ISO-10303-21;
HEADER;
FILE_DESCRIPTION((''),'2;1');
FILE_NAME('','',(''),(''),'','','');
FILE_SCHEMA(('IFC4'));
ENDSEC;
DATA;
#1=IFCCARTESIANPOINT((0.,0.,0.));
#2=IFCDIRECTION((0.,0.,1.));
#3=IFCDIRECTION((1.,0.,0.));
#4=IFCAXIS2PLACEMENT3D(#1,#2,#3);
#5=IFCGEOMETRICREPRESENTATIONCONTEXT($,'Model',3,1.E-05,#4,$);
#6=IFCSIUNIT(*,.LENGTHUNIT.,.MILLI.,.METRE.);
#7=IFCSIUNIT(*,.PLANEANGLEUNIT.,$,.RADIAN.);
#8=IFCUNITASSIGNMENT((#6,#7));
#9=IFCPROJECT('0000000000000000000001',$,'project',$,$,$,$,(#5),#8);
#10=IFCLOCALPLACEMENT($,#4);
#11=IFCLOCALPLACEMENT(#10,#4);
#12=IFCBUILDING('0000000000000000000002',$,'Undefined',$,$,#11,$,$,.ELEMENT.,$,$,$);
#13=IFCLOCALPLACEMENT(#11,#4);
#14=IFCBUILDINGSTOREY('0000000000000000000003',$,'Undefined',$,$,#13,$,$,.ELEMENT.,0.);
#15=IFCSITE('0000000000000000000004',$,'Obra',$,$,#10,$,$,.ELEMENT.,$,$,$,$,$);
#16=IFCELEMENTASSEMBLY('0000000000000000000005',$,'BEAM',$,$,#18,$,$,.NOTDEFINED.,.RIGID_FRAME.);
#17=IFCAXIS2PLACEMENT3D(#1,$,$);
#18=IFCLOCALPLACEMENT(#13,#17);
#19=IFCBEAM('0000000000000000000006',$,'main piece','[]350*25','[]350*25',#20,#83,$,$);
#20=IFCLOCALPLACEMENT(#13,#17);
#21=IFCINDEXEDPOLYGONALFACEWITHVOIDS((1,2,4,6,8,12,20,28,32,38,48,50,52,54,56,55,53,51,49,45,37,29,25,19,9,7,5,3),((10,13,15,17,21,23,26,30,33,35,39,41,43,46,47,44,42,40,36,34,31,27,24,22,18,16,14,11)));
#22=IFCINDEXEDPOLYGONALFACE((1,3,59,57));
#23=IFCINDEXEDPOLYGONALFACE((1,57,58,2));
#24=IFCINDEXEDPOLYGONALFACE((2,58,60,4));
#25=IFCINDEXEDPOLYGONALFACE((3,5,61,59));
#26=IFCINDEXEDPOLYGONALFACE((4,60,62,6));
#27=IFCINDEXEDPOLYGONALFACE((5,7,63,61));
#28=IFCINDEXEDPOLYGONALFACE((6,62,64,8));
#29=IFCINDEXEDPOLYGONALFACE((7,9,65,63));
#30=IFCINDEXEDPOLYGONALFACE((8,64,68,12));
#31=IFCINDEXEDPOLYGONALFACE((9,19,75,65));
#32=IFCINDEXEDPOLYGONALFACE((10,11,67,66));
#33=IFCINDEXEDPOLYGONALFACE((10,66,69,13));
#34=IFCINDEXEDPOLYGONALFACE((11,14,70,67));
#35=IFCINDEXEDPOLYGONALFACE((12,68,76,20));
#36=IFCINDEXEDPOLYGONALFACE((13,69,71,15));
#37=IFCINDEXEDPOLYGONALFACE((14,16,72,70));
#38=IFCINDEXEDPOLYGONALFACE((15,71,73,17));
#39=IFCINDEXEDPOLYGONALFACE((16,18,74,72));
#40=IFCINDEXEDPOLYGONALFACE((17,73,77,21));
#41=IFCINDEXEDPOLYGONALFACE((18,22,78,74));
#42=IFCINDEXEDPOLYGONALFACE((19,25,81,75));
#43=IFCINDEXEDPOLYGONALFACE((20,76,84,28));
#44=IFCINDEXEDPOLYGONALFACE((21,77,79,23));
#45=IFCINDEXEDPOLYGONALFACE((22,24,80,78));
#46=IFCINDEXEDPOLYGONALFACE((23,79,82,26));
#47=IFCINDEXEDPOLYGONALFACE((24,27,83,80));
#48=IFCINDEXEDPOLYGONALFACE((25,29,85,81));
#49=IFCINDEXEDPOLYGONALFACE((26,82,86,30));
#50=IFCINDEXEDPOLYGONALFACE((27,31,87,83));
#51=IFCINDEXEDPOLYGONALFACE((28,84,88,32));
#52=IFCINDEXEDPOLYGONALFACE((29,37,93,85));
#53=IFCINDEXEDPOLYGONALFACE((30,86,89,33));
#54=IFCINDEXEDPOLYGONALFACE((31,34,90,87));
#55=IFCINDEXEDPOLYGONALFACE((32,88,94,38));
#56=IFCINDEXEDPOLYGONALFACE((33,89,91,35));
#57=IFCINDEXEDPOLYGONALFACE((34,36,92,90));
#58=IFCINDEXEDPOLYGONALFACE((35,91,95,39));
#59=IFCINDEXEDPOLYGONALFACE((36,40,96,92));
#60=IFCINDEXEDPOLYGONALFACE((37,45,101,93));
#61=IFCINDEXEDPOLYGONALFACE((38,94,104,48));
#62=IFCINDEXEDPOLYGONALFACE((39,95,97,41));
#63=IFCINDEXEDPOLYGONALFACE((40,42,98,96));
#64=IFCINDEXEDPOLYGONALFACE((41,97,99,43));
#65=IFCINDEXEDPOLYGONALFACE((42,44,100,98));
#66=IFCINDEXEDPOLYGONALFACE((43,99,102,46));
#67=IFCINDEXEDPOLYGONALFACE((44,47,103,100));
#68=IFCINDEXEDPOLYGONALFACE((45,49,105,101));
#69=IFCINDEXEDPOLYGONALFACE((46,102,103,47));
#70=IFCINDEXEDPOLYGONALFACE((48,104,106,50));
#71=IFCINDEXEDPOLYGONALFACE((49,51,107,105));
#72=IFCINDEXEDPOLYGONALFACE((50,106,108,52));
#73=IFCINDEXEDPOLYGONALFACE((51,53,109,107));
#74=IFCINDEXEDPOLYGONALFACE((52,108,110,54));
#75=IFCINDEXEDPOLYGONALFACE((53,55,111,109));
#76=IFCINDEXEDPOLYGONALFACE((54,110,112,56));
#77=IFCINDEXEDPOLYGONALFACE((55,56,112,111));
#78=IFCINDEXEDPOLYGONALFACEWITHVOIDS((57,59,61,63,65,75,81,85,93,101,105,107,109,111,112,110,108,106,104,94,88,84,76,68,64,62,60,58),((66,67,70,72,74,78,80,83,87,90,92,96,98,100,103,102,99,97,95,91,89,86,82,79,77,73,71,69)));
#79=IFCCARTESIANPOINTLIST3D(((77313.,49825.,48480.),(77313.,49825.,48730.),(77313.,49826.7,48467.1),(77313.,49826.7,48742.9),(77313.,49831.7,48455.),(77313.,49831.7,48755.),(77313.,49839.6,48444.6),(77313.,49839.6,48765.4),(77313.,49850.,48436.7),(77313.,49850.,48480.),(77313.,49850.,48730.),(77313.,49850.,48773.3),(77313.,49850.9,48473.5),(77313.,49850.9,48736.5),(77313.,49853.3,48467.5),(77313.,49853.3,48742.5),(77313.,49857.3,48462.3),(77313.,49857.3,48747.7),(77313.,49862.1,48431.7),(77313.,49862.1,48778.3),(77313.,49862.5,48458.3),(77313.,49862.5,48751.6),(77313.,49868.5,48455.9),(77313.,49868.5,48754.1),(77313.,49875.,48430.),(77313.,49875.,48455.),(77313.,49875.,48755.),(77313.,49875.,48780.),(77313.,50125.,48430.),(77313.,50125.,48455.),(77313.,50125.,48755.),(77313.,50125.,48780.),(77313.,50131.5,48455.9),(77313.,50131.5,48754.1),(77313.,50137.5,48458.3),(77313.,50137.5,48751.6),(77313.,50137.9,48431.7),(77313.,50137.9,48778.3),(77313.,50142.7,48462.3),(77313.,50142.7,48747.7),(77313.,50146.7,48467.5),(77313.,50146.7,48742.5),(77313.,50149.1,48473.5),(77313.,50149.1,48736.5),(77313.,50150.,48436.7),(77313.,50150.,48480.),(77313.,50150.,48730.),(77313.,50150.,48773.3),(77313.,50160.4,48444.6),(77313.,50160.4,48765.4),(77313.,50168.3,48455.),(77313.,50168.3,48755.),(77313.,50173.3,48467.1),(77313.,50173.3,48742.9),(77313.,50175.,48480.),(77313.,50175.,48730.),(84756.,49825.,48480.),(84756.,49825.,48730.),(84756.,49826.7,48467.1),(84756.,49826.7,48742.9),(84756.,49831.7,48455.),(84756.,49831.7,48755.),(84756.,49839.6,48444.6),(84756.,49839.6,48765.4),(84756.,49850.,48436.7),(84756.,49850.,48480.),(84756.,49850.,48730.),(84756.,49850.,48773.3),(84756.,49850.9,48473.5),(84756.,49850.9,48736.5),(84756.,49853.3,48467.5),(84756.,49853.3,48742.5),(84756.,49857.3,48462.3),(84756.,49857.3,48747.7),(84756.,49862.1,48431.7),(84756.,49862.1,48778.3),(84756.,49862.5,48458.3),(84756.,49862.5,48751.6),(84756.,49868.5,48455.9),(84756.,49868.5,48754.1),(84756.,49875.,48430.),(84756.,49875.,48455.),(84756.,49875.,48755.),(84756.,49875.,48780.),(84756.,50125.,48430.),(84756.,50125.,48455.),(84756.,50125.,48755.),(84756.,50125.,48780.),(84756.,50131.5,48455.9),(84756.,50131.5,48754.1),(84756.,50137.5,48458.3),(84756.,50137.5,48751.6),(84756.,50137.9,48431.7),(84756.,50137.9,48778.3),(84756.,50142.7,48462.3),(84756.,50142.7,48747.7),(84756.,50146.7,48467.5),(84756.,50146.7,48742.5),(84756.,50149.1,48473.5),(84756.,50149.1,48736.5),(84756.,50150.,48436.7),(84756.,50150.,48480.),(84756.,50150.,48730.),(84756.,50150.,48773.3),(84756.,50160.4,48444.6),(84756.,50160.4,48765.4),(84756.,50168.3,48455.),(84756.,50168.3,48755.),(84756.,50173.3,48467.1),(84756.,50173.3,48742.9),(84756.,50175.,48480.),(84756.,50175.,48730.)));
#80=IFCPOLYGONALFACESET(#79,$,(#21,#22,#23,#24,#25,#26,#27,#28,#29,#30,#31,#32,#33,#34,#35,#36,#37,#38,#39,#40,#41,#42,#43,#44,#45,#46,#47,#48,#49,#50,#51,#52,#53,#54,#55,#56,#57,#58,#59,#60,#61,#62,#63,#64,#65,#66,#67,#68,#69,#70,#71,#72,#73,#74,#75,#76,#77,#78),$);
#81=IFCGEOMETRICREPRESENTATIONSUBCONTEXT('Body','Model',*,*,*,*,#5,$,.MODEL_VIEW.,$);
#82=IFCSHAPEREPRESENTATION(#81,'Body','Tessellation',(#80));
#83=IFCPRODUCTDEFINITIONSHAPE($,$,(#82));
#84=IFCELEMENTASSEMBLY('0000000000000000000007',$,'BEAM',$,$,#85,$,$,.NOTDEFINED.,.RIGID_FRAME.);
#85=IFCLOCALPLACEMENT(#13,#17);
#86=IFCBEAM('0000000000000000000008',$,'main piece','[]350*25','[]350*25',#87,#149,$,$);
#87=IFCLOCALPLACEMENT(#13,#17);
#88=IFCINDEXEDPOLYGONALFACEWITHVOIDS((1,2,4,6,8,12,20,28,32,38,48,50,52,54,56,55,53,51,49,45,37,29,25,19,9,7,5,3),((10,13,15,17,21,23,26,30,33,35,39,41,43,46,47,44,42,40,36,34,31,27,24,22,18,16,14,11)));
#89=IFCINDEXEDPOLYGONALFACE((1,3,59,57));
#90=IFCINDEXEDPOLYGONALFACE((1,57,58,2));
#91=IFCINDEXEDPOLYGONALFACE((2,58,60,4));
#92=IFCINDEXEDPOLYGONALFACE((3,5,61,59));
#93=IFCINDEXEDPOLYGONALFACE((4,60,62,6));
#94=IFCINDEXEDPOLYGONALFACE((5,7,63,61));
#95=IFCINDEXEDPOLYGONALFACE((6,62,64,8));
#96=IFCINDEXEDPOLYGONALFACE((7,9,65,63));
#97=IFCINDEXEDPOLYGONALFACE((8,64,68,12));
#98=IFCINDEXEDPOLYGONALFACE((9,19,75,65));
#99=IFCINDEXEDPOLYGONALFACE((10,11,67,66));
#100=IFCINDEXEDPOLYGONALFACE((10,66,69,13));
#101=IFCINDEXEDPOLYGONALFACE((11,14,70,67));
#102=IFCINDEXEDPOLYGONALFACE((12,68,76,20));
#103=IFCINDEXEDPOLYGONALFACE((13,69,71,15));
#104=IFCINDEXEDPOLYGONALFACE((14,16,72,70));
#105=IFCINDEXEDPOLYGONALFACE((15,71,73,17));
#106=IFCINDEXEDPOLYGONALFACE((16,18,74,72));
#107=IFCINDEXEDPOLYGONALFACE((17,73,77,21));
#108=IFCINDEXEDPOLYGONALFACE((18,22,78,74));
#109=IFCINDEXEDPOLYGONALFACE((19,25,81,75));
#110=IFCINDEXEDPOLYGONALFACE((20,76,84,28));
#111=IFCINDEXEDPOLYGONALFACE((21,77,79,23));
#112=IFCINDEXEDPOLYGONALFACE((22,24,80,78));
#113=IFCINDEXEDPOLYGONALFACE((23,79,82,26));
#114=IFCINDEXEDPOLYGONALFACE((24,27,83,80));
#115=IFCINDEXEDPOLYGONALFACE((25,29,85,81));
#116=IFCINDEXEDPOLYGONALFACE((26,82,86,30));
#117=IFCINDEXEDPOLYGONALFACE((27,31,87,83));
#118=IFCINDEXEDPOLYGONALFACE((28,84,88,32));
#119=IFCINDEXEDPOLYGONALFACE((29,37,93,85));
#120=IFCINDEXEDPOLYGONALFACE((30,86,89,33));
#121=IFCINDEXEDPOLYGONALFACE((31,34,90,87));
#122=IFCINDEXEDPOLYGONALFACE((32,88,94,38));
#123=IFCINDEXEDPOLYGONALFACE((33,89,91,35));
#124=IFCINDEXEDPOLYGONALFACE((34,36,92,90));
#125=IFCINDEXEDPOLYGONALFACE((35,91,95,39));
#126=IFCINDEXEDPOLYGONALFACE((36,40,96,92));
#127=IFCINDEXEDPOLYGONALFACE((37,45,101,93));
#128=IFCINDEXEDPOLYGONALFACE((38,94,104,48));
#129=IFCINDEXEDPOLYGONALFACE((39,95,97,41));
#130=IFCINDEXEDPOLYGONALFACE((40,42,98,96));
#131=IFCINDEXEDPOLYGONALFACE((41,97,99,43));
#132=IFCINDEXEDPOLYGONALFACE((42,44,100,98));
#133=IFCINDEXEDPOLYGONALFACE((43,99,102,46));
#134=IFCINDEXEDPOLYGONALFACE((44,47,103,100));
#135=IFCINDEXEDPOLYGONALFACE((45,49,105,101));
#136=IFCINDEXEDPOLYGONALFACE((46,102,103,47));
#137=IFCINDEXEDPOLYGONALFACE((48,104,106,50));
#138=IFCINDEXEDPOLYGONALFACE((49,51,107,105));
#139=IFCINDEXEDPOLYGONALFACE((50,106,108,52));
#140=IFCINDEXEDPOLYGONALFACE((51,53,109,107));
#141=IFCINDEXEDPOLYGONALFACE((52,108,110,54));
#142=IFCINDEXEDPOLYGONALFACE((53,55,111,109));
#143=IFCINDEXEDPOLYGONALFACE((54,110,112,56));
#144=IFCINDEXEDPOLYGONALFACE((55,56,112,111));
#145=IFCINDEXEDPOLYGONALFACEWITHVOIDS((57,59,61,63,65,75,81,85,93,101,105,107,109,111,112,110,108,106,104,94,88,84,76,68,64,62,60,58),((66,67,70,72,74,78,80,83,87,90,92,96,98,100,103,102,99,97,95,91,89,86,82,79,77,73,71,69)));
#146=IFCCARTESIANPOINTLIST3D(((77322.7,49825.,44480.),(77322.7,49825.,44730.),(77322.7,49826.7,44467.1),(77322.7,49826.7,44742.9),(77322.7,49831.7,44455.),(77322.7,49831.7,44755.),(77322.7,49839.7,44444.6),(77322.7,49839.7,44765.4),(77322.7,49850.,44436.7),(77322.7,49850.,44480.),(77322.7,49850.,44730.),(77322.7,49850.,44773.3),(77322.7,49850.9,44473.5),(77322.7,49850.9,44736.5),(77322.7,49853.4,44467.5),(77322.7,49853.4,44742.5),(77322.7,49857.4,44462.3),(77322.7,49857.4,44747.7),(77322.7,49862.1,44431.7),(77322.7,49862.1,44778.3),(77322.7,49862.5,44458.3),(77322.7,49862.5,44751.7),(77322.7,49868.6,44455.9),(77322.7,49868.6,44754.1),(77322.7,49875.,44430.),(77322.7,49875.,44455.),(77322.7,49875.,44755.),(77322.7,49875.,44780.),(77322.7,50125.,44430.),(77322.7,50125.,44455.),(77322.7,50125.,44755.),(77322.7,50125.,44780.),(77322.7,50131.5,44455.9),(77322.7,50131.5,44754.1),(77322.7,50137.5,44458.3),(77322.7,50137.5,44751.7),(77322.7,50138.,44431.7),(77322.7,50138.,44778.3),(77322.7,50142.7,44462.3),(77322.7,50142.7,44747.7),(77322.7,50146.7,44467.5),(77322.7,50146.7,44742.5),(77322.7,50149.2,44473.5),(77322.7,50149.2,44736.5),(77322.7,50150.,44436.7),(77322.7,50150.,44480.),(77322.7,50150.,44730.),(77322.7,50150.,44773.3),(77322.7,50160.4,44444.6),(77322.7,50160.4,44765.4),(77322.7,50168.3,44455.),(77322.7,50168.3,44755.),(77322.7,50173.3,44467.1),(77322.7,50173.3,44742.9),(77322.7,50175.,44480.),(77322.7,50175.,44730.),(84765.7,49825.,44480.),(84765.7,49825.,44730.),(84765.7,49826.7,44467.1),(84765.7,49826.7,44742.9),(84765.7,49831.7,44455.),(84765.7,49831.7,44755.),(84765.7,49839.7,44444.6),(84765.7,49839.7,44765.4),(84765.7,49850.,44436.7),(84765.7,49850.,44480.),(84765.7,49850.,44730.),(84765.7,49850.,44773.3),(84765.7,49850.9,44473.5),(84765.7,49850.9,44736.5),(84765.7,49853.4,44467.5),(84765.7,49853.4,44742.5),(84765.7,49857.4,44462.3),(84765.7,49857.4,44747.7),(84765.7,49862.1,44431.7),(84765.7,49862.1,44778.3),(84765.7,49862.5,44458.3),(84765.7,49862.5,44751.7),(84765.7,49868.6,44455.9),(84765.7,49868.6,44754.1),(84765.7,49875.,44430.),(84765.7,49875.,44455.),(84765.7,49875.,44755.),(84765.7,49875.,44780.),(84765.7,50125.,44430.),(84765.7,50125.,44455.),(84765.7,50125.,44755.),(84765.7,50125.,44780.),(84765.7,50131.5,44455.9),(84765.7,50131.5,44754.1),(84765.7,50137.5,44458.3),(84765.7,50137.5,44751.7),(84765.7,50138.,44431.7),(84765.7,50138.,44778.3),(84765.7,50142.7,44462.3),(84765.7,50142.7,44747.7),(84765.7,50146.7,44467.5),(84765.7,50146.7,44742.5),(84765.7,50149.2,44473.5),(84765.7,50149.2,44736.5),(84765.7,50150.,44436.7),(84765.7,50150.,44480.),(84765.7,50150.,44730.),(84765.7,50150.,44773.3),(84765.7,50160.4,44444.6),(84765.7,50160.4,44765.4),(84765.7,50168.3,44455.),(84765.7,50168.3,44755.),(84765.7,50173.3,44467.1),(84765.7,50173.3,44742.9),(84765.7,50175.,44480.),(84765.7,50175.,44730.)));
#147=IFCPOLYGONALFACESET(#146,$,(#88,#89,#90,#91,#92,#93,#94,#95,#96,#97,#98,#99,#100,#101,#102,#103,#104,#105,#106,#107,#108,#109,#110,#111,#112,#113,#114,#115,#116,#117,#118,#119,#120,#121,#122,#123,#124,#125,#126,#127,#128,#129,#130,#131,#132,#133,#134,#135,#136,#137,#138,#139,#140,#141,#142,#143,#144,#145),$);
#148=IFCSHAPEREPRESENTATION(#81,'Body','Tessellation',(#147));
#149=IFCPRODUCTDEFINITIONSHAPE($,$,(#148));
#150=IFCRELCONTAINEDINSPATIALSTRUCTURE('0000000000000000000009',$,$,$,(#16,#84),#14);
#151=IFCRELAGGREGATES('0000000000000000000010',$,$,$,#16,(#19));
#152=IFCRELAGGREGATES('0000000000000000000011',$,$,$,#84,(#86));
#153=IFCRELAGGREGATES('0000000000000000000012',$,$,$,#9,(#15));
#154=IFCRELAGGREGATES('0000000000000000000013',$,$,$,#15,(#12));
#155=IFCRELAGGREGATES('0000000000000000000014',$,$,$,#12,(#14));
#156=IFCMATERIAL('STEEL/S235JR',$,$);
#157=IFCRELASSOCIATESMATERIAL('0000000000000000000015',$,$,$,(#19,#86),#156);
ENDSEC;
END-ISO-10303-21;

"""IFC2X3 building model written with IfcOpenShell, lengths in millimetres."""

from ifc_helpers import new_model, si_unit, frame, origin_with_axes, origin_2d_with_axis, place, context, subcontext, project, spatial, hollow_rectangle, extrude, material, element, aggregate, save


model = new_model("IFC2X3")

# Units and contexts
model_context = context("Model", 3, precision=1e-05, world=origin_with_axes())
body_context = subcontext(model_context, "Body", "Model", "MODEL_VIEW")
ifc_project = project(units=[si_unit("LENGTHUNIT", "METRE", prefix="MILLI"), si_unit("PLANEANGLEUNIT", "RADIAN")], contexts=[model_context])

# Site, building, storey
site_placement = place(None, origin_with_axes())
site = spatial("IfcSite", under=ifc_project, at=site_placement, Name="Obra", CompositionType="ELEMENT")
building_placement = place(site_placement, origin_with_axes())
building = spatial("IfcBuilding", under=site, at=building_placement, Name="Undefined", CompositionType="ELEMENT")
storey_placement = place(building_placement, origin_with_axes())
storey = spatial("IfcBuildingStorey", under=building, at=storey_placement, Name="Undefined", CompositionType="ELEMENT", Elevation=0.0)

# Shared definitions
ifc_material = material(Name="STEEL/S235JR")

# Element assemblies, beams
assembly_1_placement = place(storey_placement, origin_with_axes())
assembly_1 = element("IfcElementAssembly", 1, at=assembly_1_placement, inside=storey, Name="BEAM", AssemblyPlace="NOTDEFINED", PredefinedType="RIGID_FRAME")
beam_1_placement = place(assembly_1_placement, frame((84756.0, 50000.0, 48605.0), z_axis=(0.0, 0.0, 1.0), x_axis=(-1.0, 0.0, 0.0)))
beam_1 = element("IfcBeam", 2, at=beam_1_placement, material=ifc_material, Name="main piece", Description="[]350*25", ObjectType="[]350*25", context=body_context, shape_type="SweptSolid", body=[
    extrude(hollow_rectangle(XDim=350.0, YDim=350.0, WallThickness=25.0, InnerFilletRadius=25.0, OuterFilletRadius=50.0, at=origin_2d_with_axis()), frame((7443.0, 0.0, 0.0), z_axis=(-1.0, 0.0, 0.0), x_axis=(0.0, -1.0, 0.0)), (0.0, 0.0, 1.0), 7443.0),
])
aggregate(assembly_1, [beam_1])
assembly_2_placement = place(storey_placement, origin_with_axes())
assembly_2 = element("IfcElementAssembly", 3, at=assembly_2_placement, inside=storey, Name="BEAM", AssemblyPlace="NOTDEFINED", PredefinedType="RIGID_FRAME")
beam_2_placement = place(assembly_2_placement, frame((84765.7, 50000.0, 44605.0), z_axis=(0.0, 0.0, 1.0), x_axis=(-1.0, 0.0, 0.0)))
beam_2 = element("IfcBeam", 4, at=beam_2_placement, material=ifc_material, Name="main piece", Description="[]350*25", ObjectType="[]350*25", context=body_context, shape_type="SweptSolid", body=[
    extrude(hollow_rectangle(XDim=350.0, YDim=350.0, WallThickness=25.0, InnerFilletRadius=25.0, OuterFilletRadius=50.0, at=origin_2d_with_axis()), frame((7443.0, 0.0, 0.0), z_axis=(-1.0, 0.0, 0.0), x_axis=(0.0, -1.0, 0.0)), (0.0, 0.0, 1.0), 7443.0),
])
aggregate(assembly_2, [beam_2])

save(model, "model.ifc")
